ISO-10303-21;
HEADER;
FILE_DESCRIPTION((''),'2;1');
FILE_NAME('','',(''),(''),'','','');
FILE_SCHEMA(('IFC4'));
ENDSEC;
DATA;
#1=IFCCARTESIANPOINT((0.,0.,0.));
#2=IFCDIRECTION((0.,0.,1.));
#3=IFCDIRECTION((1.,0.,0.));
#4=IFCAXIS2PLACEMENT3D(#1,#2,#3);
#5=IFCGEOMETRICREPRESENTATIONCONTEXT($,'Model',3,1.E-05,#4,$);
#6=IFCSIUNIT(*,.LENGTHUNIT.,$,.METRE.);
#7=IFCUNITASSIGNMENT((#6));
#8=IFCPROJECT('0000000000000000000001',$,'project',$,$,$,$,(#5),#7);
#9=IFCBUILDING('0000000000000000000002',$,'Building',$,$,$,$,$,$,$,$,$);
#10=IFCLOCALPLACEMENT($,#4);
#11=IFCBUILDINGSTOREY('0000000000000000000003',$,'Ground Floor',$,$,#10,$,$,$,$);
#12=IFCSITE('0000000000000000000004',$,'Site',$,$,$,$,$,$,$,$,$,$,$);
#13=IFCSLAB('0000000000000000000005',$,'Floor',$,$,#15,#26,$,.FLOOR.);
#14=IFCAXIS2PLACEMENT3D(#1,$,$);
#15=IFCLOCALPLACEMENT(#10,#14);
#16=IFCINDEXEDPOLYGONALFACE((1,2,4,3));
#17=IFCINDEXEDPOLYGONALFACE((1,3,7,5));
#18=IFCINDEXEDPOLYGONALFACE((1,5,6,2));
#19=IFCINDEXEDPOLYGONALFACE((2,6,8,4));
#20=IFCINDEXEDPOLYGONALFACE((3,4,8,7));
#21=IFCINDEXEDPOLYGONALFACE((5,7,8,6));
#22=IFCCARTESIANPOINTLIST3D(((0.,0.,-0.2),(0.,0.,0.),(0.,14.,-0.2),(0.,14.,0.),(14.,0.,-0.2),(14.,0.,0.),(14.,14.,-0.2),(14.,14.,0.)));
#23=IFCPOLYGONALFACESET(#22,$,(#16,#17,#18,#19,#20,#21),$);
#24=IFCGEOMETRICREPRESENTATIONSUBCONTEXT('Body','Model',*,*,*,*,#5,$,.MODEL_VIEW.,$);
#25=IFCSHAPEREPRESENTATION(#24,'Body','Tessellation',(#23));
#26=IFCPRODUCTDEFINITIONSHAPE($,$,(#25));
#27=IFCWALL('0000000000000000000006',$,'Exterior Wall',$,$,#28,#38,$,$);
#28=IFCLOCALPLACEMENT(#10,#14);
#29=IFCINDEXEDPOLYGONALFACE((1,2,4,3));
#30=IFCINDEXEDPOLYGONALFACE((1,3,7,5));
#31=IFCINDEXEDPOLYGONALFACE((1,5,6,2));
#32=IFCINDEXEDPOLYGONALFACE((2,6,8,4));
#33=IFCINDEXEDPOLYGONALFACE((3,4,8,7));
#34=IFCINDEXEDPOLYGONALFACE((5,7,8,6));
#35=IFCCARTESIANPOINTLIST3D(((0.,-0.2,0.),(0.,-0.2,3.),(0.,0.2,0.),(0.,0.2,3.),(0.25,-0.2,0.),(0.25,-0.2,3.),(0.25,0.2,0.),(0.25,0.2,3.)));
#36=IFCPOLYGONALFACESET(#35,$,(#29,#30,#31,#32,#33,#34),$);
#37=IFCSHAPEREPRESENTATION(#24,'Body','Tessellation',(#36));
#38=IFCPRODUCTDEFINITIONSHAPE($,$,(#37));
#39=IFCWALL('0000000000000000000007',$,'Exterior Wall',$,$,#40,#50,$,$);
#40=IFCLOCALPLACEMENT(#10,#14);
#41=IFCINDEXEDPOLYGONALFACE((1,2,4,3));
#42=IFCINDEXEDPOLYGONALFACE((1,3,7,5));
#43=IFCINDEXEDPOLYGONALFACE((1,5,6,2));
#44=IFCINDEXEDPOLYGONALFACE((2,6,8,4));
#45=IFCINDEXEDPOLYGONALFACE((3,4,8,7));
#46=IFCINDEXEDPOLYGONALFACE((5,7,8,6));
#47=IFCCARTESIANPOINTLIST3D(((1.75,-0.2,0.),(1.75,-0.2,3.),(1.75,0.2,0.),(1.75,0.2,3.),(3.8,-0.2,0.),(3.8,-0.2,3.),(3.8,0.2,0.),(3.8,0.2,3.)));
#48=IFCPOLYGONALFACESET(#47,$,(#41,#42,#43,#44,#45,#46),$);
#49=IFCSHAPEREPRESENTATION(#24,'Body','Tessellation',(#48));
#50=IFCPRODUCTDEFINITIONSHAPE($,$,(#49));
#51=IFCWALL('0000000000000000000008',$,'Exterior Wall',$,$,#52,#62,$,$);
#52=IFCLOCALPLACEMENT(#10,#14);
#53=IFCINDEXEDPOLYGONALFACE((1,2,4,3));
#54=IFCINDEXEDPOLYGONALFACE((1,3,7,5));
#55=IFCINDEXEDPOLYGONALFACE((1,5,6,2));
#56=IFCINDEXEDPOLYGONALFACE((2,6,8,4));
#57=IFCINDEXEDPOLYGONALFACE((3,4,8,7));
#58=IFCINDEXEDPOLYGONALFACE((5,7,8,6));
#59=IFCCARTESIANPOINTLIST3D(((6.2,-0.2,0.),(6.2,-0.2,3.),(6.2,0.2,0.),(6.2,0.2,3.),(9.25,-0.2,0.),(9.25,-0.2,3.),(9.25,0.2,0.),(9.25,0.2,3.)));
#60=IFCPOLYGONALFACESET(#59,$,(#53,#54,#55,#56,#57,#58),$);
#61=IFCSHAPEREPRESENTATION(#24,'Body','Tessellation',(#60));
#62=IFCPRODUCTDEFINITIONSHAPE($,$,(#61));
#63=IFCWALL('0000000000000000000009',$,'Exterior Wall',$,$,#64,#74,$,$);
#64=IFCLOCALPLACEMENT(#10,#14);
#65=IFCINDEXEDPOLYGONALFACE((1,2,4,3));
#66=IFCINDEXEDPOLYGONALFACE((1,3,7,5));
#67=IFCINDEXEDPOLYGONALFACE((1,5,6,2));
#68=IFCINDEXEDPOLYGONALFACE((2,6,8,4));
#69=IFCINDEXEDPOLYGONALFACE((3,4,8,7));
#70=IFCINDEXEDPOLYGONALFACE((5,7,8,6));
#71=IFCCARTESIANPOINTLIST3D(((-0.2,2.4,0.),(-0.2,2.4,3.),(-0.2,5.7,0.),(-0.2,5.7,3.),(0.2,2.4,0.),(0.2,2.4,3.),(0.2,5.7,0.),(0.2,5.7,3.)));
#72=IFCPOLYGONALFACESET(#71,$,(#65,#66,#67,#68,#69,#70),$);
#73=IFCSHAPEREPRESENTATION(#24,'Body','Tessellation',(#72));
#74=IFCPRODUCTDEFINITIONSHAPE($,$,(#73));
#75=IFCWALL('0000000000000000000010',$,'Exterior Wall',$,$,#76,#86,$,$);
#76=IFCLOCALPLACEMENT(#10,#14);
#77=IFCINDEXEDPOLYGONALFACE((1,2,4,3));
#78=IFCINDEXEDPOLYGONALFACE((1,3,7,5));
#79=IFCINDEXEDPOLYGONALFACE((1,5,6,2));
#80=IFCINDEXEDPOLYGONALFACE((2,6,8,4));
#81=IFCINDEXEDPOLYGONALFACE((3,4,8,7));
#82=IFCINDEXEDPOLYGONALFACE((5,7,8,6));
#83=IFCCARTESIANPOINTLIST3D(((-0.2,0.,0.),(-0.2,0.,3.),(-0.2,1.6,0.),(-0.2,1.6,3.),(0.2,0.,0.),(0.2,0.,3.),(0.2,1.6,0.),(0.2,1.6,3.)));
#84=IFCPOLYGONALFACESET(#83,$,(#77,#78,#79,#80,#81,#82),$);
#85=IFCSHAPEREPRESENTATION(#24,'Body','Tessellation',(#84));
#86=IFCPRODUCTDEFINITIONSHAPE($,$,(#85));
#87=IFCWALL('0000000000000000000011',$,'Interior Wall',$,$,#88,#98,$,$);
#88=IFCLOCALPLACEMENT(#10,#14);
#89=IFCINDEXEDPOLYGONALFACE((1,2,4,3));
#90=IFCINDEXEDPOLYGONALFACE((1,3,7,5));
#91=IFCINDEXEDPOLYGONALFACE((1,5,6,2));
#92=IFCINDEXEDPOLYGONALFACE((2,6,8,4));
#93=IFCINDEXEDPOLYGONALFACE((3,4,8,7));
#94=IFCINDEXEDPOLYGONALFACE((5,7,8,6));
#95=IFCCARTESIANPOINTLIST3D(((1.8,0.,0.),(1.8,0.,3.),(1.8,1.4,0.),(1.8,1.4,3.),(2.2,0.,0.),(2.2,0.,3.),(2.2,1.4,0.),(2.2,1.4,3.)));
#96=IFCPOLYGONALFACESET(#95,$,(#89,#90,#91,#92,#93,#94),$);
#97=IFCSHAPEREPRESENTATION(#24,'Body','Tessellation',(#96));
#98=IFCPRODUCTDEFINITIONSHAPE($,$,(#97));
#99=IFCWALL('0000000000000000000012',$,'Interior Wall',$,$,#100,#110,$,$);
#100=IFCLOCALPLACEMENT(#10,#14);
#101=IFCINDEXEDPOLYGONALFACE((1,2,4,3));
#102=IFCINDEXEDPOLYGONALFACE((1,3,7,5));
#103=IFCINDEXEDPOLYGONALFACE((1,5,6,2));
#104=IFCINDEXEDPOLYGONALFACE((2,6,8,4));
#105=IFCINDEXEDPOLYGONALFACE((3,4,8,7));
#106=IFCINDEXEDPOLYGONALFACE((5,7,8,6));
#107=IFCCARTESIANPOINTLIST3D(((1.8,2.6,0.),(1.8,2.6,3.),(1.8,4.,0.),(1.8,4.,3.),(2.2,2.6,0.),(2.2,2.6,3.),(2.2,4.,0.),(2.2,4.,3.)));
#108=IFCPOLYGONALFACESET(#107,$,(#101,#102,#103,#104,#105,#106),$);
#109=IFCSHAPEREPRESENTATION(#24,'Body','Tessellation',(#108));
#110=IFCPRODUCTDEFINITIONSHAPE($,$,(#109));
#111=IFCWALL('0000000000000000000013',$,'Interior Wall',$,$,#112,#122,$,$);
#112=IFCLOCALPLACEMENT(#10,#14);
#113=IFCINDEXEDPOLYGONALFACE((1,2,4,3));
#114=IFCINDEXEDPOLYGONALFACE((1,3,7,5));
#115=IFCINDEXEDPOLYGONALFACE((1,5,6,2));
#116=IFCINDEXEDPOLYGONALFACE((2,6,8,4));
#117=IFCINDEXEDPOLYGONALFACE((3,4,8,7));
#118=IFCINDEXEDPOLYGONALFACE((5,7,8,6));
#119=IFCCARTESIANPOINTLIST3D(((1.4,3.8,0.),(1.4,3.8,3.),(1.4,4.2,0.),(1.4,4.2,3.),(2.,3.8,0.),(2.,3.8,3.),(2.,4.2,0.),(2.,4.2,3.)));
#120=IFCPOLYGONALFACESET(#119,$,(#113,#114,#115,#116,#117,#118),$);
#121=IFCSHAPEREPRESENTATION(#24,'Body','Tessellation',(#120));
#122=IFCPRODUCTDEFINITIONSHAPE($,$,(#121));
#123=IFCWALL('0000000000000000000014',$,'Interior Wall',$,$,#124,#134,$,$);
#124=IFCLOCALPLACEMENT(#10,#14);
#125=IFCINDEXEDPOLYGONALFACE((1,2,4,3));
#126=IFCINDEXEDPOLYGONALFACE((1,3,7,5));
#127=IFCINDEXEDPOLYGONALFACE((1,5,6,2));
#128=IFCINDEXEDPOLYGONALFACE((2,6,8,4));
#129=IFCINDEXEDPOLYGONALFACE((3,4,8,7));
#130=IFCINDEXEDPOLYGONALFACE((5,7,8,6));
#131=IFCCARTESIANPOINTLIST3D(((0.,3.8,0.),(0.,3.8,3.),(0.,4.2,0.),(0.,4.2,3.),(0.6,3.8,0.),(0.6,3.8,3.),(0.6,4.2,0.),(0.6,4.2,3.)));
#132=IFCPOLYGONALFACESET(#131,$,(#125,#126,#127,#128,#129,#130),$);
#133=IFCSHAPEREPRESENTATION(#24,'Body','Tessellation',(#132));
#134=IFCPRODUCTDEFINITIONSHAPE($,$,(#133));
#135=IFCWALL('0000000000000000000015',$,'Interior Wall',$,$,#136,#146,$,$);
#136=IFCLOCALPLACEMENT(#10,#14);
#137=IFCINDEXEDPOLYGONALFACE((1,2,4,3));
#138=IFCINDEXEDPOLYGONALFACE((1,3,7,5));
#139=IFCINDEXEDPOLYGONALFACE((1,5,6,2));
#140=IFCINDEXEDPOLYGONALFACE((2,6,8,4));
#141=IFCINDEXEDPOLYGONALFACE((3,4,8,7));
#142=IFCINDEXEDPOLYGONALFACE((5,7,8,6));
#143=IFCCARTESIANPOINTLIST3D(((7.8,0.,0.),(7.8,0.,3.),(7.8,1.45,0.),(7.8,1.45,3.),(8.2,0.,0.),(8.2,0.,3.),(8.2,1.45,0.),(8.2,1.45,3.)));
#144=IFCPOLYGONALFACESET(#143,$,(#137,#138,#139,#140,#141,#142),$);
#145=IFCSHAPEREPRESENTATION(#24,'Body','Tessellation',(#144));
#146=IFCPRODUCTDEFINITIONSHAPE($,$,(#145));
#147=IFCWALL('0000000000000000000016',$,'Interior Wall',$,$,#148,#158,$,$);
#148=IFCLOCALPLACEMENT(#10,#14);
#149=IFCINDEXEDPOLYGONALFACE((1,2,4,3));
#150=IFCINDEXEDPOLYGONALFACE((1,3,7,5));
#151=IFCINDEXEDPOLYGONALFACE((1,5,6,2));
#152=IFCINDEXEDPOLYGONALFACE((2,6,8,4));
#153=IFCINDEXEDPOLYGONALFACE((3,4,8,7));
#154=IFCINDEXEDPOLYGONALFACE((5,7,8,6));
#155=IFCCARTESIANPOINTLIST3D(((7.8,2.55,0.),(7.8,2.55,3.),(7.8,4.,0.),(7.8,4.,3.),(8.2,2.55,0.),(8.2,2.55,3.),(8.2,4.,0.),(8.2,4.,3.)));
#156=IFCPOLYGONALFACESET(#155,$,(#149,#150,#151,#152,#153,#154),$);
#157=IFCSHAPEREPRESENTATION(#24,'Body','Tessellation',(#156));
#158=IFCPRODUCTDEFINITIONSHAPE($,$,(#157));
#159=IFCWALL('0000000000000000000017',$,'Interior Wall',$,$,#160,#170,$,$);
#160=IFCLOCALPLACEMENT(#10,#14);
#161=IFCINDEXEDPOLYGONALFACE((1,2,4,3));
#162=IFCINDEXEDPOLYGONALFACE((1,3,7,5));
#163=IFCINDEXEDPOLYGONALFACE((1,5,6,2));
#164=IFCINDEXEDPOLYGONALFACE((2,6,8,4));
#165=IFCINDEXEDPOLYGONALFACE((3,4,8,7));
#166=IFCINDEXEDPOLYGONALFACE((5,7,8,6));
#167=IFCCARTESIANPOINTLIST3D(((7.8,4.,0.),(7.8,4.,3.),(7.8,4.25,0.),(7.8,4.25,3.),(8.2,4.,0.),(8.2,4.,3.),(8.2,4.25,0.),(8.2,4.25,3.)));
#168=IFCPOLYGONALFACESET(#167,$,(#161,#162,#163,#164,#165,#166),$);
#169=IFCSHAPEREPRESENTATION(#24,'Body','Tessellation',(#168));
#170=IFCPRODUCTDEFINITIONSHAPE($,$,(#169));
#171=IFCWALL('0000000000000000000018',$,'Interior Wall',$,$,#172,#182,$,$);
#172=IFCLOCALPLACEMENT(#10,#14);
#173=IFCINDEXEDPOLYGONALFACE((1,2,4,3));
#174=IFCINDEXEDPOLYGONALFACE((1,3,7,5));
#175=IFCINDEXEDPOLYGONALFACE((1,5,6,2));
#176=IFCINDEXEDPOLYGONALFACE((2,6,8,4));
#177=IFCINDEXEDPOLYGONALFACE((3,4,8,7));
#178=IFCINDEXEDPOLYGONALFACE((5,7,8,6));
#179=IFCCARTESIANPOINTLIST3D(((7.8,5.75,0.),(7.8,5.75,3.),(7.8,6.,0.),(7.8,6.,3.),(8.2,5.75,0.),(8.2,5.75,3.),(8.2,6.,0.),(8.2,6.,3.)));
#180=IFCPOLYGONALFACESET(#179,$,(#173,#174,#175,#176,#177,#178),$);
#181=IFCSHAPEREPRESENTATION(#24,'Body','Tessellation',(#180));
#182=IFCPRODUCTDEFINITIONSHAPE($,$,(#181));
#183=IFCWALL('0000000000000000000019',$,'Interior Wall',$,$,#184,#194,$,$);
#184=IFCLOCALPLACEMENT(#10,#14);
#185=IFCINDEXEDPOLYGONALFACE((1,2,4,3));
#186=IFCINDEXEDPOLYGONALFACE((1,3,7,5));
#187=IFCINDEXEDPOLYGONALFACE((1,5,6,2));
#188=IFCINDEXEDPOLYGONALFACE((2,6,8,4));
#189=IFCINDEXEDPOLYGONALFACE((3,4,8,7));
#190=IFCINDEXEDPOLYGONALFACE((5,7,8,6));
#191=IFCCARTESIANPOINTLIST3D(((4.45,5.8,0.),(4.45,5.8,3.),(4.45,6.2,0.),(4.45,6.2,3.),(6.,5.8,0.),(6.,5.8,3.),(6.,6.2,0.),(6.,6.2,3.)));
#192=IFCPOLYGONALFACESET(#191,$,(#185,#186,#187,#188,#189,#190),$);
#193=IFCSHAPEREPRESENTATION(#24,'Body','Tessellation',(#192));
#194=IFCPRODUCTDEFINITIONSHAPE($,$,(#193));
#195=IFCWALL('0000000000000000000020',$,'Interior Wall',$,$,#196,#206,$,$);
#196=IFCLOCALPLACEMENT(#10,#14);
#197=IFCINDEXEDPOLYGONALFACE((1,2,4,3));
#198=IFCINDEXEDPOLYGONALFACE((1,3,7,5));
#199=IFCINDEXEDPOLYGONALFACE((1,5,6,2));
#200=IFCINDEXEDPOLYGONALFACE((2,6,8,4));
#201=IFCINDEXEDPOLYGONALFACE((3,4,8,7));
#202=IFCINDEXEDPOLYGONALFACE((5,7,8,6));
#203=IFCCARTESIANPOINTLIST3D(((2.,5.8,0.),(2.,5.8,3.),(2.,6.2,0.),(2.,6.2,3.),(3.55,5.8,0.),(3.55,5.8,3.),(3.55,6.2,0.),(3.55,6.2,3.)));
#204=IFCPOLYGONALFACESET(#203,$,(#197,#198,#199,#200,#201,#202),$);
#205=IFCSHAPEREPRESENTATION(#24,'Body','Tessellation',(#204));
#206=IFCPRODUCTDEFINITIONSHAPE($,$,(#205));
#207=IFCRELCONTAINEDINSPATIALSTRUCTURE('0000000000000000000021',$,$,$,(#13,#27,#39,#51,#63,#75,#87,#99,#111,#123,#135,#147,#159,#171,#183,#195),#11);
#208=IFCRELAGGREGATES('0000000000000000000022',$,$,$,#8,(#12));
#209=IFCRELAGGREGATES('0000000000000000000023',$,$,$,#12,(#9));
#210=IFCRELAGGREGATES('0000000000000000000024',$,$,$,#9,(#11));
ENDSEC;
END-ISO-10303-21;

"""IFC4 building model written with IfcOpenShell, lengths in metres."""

from ifc_helpers import new_model, si_unit, frame, origin_with_axes, place, context, subcontext, project, spatial, indexed_curve, outline, extrude, element, save


model = new_model("IFC4")

# Units and contexts
model_context = context("Model", 3, precision=1e-05, world=origin_with_axes())
body_context = subcontext(model_context, "Body", "Model", "MODEL_VIEW")
ifc_project = project(units=[si_unit("LENGTHUNIT", "METRE")], contexts=[model_context])

# Site, building, storey
site = spatial("IfcSite", under=ifc_project, Name="Site")
building = spatial("IfcBuilding", under=site, Name="Building")
storey_placement = place(None, origin_with_axes())
storey = spatial("IfcBuildingStorey", under=building, at=storey_placement, Name="Ground Floor")

# Slab
slab_placement = place(storey_placement, frame((0.0, 0.0, -0.2), z_axis=(0.0, 0.0, 1.0), x_axis=(1.0, 0.0, 0.0)))
element("IfcSlab", 1, at=slab_placement, inside=storey, Name="Floor", PredefinedType="FLOOR", context=body_context, shape_type="SweptSolid", body=[
    extrude(outline(indexed_curve([(0.0, 0.0), (14.0, 0.0), (14.0, 14.0), (0.0, 14.0)])), None, (0.0, 0.0, 1.0), 0.2),
])

# Walls
wall_1_placement = place(storey_placement, origin_with_axes())
element("IfcWall", 2, at=wall_1_placement, inside=storey, Name="Exterior Wall", context=body_context, shape_type="SweptSolid", body=[
    extrude(outline(indexed_curve([(0.0, 0.0), (0.0, 0.4), (0.25, 0.4), (0.25, 0.0), (0.0, 0.0)], self_intersect=False)), frame((0.0, -0.2, 0.0), z_axis=(0.0, 0.0, 1.0), x_axis=(1.0, 0.0, 0.0)), (0.0, 0.0, 1.0), 3.0),
])
wall_2_placement = place(storey_placement, frame((1.75, 0.0, 0.0), z_axis=(0.0, 0.0, 1.0), x_axis=(1.0, 0.0, 0.0)))
element("IfcWall", 3, at=wall_2_placement, inside=storey, Name="Exterior Wall", context=body_context, shape_type="SweptSolid", body=[
    extrude(outline(indexed_curve([(0.0, 0.0), (0.0, 0.4), (2.05, 0.4), (2.05, 0.0), (0.0, 0.0)], self_intersect=False)), frame((0.0, -0.2, 0.0), z_axis=(0.0, 0.0, 1.0), x_axis=(1.0, 0.0, 0.0)), (0.0, 0.0, 1.0), 3.0),
])
wall_3_placement = place(storey_placement, frame((6.2, 0.0, 0.0), z_axis=(0.0, 0.0, 1.0), x_axis=(1.0, 0.0, 0.0)))
element("IfcWall", 4, at=wall_3_placement, inside=storey, Name="Exterior Wall", context=body_context, shape_type="SweptSolid", body=[
    extrude(outline(indexed_curve([(0.0, 0.0), (0.0, 0.4), (3.05, 0.4), (3.05, 0.0), (0.0, 0.0)], self_intersect=False)), frame((0.0, -0.2, 0.0), z_axis=(0.0, 0.0, 1.0), x_axis=(1.0, 0.0, 0.0)), (0.0, 0.0, 1.0), 3.0),
])
wall_4_placement = place(storey_placement, frame((0.0, 5.7, 0.0), z_axis=(0.0, 0.0, 1.0), x_axis=(0.0, -1.0, 0.0)))
element("IfcWall", 5, at=wall_4_placement, inside=storey, Name="Exterior Wall", context=body_context, shape_type="SweptSolid", body=[
    extrude(outline(indexed_curve([(0.0, 0.0), (0.0, 0.4), (3.3, 0.4), (3.3, 0.0), (0.0, 0.0)], self_intersect=False)), frame((0.0, -0.2, 0.0), z_axis=(0.0, 0.0, 1.0), x_axis=(1.0, 0.0, 0.0)), (0.0, 0.0, 1.0), 3.0),
])
wall_5_placement = place(storey_placement, frame((0.0, 1.6, 0.0), z_axis=(0.0, 0.0, 1.0), x_axis=(0.0, -1.0, 0.0)))
element("IfcWall", 6, at=wall_5_placement, inside=storey, Name="Exterior Wall", context=body_context, shape_type="SweptSolid", body=[
    extrude(outline(indexed_curve([(0.0, 0.0), (0.0, 0.4), (1.6, 0.4), (1.6, 0.0), (0.0, 0.0)], self_intersect=False)), frame((0.0, -0.2, 0.0), z_axis=(0.0, 0.0, 1.0), x_axis=(1.0, 0.0, 0.0)), (0.0, 0.0, 1.0), 3.0),
])
for number, where, z_axis, x_axis, name in (
    (7, (2.0, 0.0, 0.0), (0.0, 0.0, 1.0), (0.0, 1.0, 0.0), "Interior Wall"),
    (8, (2.0, 2.6, 0.0), (0.0, 0.0, 1.0), (0.0, 1.0, 0.0), "Interior Wall"),
):
    element("IfcWall", number, at=place(storey_placement, frame(where, z_axis=z_axis, x_axis=x_axis)), inside=storey, Name=name, context=body_context, shape_type="SweptSolid", body=[
        extrude(outline(indexed_curve([(0.0, 0.0), (0.0, 0.4), (1.4, 0.4), (1.4, 0.0), (0.0, 0.0)], self_intersect=False)), frame((0.0, -0.2, 0.0), z_axis=(0.0, 0.0, 1.0), x_axis=(1.0, 0.0, 0.0)), (0.0, 0.0, 1.0), 3.0),
    ])
for number, where, z_axis, x_axis, name in (
    (9, (2.0, 4.0, 0.0), (0.0, 0.0, 1.0), (-1.0, 0.0, 0.0), "Interior Wall"),
    (10, (0.6, 4.0, 0.0), (0.0, 0.0, 1.0), (-1.0, 0.0, 0.0), "Interior Wall"),
):
    element("IfcWall", number, at=place(storey_placement, frame(where, z_axis=z_axis, x_axis=x_axis)), inside=storey, Name=name, context=body_context, shape_type="SweptSolid", body=[
        extrude(outline(indexed_curve([(0.0, 0.0), (0.0, 0.4), (0.6, 0.4), (0.6, 0.0), (0.0, 0.0)], self_intersect=False)), frame((0.0, -0.2, 0.0), z_axis=(0.0, 0.0, 1.0), x_axis=(1.0, 0.0, 0.0)), (0.0, 0.0, 1.0), 3.0),
    ])
wall_6_placement = place(storey_placement, frame((8.0, 0.0, 0.0), z_axis=(0.0, 0.0, 1.0), x_axis=(0.0, 1.0, 0.0)))
element("IfcWall", 11, at=wall_6_placement, inside=storey, Name="Interior Wall", context=body_context, shape_type="SweptSolid", body=[
    extrude(outline(indexed_curve([(0.0, 0.0), (0.0, 0.4), (1.45, 0.4), (1.45, 0.0), (0.0, 0.0)], self_intersect=False)), frame((0.0, -0.2, 0.0), z_axis=(0.0, 0.0, 1.0), x_axis=(1.0, 0.0, 0.0)), (0.0, 0.0, 1.0), 3.0),
])
wall_7_placement = place(storey_placement, frame((8.0, 2.55, 0.0), z_axis=(0.0, 0.0, 1.0), x_axis=(0.0, 1.0, 0.0)))
element("IfcWall", 12, at=wall_7_placement, inside=storey, Name="Interior Wall", context=body_context, shape_type="SweptSolid", body=[
    extrude(outline(indexed_curve([(0.0, 0.0), (0.0, 0.4), (1.45, 0.4), (1.45, 0.0), (0.0, 0.0)], self_intersect=False)), frame((0.0, -0.2, 0.0), z_axis=(0.0, 0.0, 1.0), x_axis=(1.0, 0.0, 0.0)), (0.0, 0.0, 1.0), 3.0),
])
for number, where, z_axis, x_axis, name in (
    (13, (8.0, 4.0, 0.0), (0.0, 0.0, 1.0), (0.0, 1.0, 0.0), "Interior Wall"),
    (14, (8.0, 5.75, 0.0), (0.0, 0.0, 1.0), (0.0, 1.0, 0.0), "Interior Wall"),
):
    element("IfcWall", number, at=place(storey_placement, frame(where, z_axis=z_axis, x_axis=x_axis)), inside=storey, Name=name, context=body_context, shape_type="SweptSolid", body=[
        extrude(outline(indexed_curve([(0.0, 0.0), (0.0, 0.4), (0.25, 0.4), (0.25, 0.0), (0.0, 0.0)], self_intersect=False)), frame((0.0, -0.2, 0.0), z_axis=(0.0, 0.0, 1.0), x_axis=(1.0, 0.0, 0.0)), (0.0, 0.0, 1.0), 3.0),
    ])
for number, where, z_axis, x_axis, name in (
    (15, (6.0, 6.0, 0.0), (0.0, 0.0, 1.0), (-1.0, 0.0, 0.0), "Interior Wall"),
    (16, (3.55, 6.0, 0.0), (0.0, 0.0, 1.0), (-1.0, 0.0, 0.0), "Interior Wall"),
):
    element("IfcWall", number, at=place(storey_placement, frame(where, z_axis=z_axis, x_axis=x_axis)), inside=storey, Name=name, context=body_context, shape_type="SweptSolid", body=[
        extrude(outline(indexed_curve([(0.0, 0.0), (0.0, 0.4), (1.55, 0.4), (1.55, 0.0), (0.0, 0.0)], self_intersect=False)), frame((0.0, -0.2, 0.0), z_axis=(0.0, 0.0, 1.0), x_axis=(1.0, 0.0, 0.0)), (0.0, 0.0, 1.0), 3.0),
    ])

save(model, "model.ifc")
